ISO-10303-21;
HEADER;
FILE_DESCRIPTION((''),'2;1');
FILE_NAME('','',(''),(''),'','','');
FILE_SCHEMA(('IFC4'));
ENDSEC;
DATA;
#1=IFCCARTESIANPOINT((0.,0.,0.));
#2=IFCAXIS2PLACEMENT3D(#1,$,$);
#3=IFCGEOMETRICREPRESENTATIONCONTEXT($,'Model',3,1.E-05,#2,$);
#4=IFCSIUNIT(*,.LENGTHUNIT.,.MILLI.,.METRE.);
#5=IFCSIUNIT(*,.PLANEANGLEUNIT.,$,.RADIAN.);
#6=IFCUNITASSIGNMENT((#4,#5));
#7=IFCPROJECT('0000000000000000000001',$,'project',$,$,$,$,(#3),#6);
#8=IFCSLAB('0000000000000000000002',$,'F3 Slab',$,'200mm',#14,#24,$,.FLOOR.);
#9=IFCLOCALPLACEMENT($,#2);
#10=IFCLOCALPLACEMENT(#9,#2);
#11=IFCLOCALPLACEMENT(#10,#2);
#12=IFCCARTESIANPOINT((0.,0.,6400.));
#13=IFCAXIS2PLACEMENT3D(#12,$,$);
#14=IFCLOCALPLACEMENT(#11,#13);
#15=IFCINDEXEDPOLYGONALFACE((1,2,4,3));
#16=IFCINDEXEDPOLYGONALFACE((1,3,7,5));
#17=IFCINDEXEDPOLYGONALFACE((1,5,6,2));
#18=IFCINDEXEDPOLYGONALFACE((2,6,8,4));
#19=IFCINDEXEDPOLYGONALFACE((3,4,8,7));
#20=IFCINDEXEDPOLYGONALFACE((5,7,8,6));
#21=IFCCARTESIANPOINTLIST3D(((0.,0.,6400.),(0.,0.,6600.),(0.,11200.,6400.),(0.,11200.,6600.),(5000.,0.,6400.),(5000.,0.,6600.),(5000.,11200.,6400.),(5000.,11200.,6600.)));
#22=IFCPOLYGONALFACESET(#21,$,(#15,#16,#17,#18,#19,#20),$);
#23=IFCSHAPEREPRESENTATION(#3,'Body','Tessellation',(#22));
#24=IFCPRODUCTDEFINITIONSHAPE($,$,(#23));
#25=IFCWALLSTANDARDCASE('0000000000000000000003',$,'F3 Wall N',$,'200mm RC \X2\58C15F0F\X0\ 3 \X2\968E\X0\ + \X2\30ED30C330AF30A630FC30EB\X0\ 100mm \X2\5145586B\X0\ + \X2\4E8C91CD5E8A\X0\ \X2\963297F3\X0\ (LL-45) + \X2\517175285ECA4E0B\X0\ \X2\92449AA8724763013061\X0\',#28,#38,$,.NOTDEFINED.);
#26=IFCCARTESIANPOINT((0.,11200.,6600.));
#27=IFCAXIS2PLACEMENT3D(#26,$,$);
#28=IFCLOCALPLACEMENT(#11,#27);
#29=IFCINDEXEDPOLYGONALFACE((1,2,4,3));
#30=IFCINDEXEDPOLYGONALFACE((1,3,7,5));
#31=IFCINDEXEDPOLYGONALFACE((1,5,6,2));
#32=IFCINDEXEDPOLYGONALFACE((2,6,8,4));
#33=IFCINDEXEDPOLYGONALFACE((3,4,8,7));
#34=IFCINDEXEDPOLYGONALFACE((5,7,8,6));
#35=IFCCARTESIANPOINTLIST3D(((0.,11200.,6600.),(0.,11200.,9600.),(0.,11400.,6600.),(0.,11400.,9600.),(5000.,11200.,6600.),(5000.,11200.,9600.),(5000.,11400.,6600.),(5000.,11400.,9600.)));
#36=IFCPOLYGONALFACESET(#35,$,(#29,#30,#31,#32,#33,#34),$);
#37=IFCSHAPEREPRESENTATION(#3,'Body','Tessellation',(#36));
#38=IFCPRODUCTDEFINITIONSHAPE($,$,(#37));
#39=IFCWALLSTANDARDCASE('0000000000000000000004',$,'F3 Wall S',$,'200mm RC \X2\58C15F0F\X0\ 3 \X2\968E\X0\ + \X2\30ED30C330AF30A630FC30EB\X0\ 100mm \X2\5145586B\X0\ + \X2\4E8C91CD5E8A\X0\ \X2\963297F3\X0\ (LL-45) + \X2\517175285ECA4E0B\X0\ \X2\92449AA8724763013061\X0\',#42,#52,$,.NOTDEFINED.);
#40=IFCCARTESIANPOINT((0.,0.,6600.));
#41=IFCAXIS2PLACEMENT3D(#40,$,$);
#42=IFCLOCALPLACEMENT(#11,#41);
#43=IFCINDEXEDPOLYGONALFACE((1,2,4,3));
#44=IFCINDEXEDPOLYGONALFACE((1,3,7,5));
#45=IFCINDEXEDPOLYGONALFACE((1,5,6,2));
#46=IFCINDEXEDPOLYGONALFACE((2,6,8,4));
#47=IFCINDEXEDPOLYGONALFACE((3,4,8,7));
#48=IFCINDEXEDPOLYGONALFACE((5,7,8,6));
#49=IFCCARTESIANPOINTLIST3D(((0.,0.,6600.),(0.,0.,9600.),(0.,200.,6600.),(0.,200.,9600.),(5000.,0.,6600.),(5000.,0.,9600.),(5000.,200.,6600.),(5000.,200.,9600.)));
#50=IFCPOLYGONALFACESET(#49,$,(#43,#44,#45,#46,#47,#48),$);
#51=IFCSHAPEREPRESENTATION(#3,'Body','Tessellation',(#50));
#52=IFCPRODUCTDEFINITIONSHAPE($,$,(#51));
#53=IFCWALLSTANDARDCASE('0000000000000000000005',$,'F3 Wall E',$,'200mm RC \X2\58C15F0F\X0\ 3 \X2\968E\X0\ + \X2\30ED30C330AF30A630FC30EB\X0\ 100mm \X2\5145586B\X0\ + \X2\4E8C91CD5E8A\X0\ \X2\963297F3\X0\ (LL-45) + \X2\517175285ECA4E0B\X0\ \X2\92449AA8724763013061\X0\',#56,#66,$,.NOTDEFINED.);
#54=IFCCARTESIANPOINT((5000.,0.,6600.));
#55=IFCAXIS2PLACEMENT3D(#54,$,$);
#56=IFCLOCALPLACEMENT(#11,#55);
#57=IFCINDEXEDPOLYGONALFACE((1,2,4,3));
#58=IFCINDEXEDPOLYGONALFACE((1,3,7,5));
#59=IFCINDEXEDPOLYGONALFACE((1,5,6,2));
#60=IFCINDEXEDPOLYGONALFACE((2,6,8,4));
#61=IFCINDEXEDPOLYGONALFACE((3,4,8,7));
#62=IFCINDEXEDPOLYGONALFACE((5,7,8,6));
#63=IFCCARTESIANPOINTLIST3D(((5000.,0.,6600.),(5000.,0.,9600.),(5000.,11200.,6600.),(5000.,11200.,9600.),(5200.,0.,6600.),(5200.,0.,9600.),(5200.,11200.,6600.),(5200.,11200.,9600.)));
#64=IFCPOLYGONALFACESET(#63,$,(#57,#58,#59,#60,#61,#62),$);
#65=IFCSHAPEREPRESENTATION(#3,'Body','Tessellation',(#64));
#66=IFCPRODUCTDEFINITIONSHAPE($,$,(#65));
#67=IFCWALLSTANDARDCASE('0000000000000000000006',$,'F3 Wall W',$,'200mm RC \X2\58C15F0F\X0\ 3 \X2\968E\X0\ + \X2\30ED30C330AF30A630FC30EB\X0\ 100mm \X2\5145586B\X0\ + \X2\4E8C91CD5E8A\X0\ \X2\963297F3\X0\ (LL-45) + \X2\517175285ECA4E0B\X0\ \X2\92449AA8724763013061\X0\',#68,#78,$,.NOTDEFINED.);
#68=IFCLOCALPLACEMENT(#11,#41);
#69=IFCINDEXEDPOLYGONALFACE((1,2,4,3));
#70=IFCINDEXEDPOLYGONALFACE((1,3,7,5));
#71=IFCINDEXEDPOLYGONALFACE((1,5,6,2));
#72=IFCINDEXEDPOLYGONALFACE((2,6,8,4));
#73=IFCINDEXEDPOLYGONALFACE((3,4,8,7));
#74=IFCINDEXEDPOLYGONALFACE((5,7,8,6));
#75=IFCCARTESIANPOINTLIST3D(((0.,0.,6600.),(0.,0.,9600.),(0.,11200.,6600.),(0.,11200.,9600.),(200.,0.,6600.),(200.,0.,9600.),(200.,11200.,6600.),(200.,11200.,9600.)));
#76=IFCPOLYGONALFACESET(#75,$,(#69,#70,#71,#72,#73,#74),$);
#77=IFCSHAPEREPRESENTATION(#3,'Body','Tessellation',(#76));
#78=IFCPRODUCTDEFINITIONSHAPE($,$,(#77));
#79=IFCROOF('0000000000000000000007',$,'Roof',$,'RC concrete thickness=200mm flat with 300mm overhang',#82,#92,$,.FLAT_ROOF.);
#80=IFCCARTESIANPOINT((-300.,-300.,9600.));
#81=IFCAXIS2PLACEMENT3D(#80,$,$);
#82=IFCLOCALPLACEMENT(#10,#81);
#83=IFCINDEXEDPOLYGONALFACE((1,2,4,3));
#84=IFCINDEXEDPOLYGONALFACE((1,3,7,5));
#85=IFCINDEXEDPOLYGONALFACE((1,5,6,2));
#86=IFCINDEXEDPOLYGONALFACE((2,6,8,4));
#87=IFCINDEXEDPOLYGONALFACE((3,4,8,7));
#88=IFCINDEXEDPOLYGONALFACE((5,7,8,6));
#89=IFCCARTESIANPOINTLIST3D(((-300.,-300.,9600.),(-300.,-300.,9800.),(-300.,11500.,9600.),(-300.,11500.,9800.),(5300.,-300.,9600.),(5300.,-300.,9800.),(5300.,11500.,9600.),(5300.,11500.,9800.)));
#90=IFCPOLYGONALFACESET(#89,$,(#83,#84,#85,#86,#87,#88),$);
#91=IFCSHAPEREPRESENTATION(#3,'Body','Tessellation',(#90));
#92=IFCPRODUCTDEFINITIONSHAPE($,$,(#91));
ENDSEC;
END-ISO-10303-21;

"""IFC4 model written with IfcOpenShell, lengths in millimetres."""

from ifc_helpers import new_model, si_unit, frame, frame_2d, origin, place, context, project, rectangle, extrude, element, save


model = new_model("IFC4")

# Units and contexts
model_context = context("Model", 3, precision=1e-05, world=origin())
ifc_project = project(units=[si_unit("LENGTHUNIT", "METRE", prefix="MILLI"), si_unit("PLANEANGLEUNIT", "RADIAN")], contexts=[model_context])

# Slab
placement_1 = place(None, origin())
placement_2 = place(placement_1, origin())
placement_3 = place(placement_2, origin())
slab_placement = place(placement_3, frame((0.0, 0.0, 6400.0)))
element("IfcSlab", 1, at=slab_placement, Name="F3 Slab", ObjectType="200mm", PredefinedType="FLOOR", context=model_context, shape_type="SweptSolid", body=[
    extrude(rectangle(XDim=5000.0, YDim=11200.0, at=frame_2d((2500.0, 5600.0))), frame((0.0, 0.0, 6400.0)), (0.0, 0.0, 1.0), 200.0),
])

# Walls
wall_1_placement = place(placement_3, frame((0.0, 11200.0, 6600.0)))
element("IfcWallStandardCase", 2, at=wall_1_placement, Name="F3 Wall N", ObjectType="200mm RC 壁式 3 階 + ロックウール 100mm 充填 + 二重床 防音 (LL-45) + 共用廊下 鉄骨片持ち", PredefinedType="NOTDEFINED", context=model_context, shape_type="SweptSolid", body=[
    extrude(rectangle(XDim=5000.0, YDim=200.0, at=frame_2d((2500.0, 100.0))), frame((0.0, 11200.0, 6600.0)), (0.0, 0.0, 1.0), 3000.0),
])
wall_2_placement = place(placement_3, frame((0.0, 0.0, 6600.0)))
element("IfcWallStandardCase", 3, at=wall_2_placement, Name="F3 Wall S", ObjectType="200mm RC 壁式 3 階 + ロックウール 100mm 充填 + 二重床 防音 (LL-45) + 共用廊下 鉄骨片持ち", PredefinedType="NOTDEFINED", context=model_context, shape_type="SweptSolid", body=[
    extrude(rectangle(XDim=5000.0, YDim=200.0, at=frame_2d((2500.0, 100.0))), frame((0.0, 0.0, 6600.0)), (0.0, 0.0, 1.0), 3000.0),
])
wall_3_placement = place(placement_3, frame((5000.0, 0.0, 6600.0)))
element("IfcWallStandardCase", 4, at=wall_3_placement, Name="F3 Wall E", ObjectType="200mm RC 壁式 3 階 + ロックウール 100mm 充填 + 二重床 防音 (LL-45) + 共用廊下 鉄骨片持ち", PredefinedType="NOTDEFINED", context=model_context, shape_type="SweptSolid", body=[
    extrude(rectangle(XDim=200.0, YDim=11200.0, at=frame_2d((100.0, 5600.0))), frame((5000.0, 0.0, 6600.0)), (0.0, 0.0, 1.0), 3000.0),
])
wall_4_placement = place(placement_3, frame((0.0, 0.0, 6600.0)))
element("IfcWallStandardCase", 5, at=wall_4_placement, Name="F3 Wall W", ObjectType="200mm RC 壁式 3 階 + ロックウール 100mm 充填 + 二重床 防音 (LL-45) + 共用廊下 鉄骨片持ち", PredefinedType="NOTDEFINED", context=model_context, shape_type="SweptSolid", body=[
    extrude(rectangle(XDim=200.0, YDim=11200.0, at=frame_2d((100.0, 5600.0))), frame((0.0, 0.0, 6600.0)), (0.0, 0.0, 1.0), 3000.0),
])

# Roof
roof_placement = place(placement_2, frame((-300.0, -300.0, 9600.0)))
element("IfcRoof", 6, at=roof_placement, Name="Roof", ObjectType="RC concrete thickness=200mm flat with 300mm overhang", PredefinedType="FLAT_ROOF", context=model_context, shape_type="SweptSolid", body=[
    extrude(rectangle(XDim=5600.0, YDim=11800.0, at=frame_2d((2800.0, 5900.0))), frame((-300.0, -300.0, 9600.0)), (0.0, 0.0, 1.0), 200.0),
])

save(model, "model.ifc")
